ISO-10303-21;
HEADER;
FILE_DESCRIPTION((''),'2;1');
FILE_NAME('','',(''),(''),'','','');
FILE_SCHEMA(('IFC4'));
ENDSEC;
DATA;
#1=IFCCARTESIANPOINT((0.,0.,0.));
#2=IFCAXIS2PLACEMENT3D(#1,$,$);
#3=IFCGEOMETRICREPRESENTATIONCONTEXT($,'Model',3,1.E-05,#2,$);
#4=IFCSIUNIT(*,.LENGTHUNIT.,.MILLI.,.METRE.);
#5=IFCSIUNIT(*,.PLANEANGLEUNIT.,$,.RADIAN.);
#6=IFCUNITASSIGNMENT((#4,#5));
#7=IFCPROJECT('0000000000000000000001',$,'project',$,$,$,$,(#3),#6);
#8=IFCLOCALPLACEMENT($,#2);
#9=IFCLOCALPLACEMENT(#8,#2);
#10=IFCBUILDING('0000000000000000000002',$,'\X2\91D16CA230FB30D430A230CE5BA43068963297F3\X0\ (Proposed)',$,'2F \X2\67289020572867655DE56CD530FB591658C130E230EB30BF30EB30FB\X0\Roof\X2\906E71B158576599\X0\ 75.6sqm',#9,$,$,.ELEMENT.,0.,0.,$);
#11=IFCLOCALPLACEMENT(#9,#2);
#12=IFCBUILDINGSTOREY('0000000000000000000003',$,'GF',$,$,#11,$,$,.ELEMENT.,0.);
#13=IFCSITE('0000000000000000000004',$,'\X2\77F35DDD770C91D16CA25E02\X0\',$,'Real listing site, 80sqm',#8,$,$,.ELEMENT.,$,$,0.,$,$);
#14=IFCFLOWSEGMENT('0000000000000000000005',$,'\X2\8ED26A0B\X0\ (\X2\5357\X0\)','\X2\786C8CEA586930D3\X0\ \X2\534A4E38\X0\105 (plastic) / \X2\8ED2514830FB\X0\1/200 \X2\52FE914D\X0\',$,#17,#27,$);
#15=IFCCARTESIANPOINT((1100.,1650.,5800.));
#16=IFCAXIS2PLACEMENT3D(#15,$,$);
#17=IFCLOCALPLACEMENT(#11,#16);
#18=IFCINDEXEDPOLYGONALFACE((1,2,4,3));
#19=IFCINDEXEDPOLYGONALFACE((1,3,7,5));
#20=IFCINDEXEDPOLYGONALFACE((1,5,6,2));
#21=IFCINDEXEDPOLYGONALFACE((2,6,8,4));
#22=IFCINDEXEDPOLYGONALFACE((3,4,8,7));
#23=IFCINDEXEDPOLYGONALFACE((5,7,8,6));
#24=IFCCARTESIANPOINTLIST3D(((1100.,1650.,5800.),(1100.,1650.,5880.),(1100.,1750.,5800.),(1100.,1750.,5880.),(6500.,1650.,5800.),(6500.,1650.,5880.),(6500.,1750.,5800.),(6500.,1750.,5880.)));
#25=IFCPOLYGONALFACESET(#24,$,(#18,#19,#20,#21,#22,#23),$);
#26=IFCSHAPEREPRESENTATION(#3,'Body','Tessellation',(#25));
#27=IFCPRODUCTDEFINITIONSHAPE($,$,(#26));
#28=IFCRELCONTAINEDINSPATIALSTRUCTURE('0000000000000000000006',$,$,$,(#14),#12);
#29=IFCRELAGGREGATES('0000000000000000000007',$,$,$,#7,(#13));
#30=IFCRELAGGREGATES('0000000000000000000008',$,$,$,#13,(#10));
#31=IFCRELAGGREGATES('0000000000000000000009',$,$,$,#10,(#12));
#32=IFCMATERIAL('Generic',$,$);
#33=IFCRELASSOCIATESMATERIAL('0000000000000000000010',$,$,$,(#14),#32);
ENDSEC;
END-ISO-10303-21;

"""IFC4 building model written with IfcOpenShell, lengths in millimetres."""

from ifc_helpers import new_model, si_unit, frame, frame_2d, origin, place, context, project, spatial, rectangle, extrude, material, element, save


model = new_model("IFC4")

# Units and contexts
model_context = context("Model", 3, precision=1e-05, world=origin())
ifc_project = project(units=[si_unit("LENGTHUNIT", "METRE", prefix="MILLI"), si_unit("PLANEANGLEUNIT", "RADIAN")], contexts=[model_context])

# Site, building, storey
site_placement = place(None, origin())
site = spatial("IfcSite", under=ifc_project, at=site_placement, Name="石川県金沢市", ObjectType="Real listing site, 80sqm", CompositionType="ELEMENT", RefElevation=0.0)
building_placement = place(site_placement, origin())
building = spatial("IfcBuilding", under=site, at=building_placement, Name="金沢・ピアノ室と防音 (Proposed)", ObjectType="2F 木造在来工法・外壁モルタル・Roof遮熱塗料 75.6sqm", CompositionType="ELEMENT", ElevationOfRefHeight=0.0, ElevationOfTerrain=0.0)
storey_placement = place(building_placement, origin())
storey = spatial("IfcBuildingStorey", under=building, at=storey_placement, Name="GF", CompositionType="ELEMENT", Elevation=0.0)

# Flow segment
ifc_material_1 = material(Name="Generic")
flow_segment_placement = place(storey_placement, frame((1100.0, 1650.0, 5800.0)))
element("IfcFlowSegment", 1, at=flow_segment_placement, inside=storey, material=ifc_material_1, Name="軒樋 (南)", Description="硬質塩ビ 半丸105 (plastic) / 軒先・1/200 勾配", context=model_context, shape_type="SweptSolid", body=[
    extrude(rectangle(XDim=5400.0, YDim=100.0, at=frame_2d((2700.0, 50.0))), frame((1100.0, 1650.0, 5800.0)), (0.0, 0.0, 1.0), 80.0),
])

save(model, "model.ifc")
